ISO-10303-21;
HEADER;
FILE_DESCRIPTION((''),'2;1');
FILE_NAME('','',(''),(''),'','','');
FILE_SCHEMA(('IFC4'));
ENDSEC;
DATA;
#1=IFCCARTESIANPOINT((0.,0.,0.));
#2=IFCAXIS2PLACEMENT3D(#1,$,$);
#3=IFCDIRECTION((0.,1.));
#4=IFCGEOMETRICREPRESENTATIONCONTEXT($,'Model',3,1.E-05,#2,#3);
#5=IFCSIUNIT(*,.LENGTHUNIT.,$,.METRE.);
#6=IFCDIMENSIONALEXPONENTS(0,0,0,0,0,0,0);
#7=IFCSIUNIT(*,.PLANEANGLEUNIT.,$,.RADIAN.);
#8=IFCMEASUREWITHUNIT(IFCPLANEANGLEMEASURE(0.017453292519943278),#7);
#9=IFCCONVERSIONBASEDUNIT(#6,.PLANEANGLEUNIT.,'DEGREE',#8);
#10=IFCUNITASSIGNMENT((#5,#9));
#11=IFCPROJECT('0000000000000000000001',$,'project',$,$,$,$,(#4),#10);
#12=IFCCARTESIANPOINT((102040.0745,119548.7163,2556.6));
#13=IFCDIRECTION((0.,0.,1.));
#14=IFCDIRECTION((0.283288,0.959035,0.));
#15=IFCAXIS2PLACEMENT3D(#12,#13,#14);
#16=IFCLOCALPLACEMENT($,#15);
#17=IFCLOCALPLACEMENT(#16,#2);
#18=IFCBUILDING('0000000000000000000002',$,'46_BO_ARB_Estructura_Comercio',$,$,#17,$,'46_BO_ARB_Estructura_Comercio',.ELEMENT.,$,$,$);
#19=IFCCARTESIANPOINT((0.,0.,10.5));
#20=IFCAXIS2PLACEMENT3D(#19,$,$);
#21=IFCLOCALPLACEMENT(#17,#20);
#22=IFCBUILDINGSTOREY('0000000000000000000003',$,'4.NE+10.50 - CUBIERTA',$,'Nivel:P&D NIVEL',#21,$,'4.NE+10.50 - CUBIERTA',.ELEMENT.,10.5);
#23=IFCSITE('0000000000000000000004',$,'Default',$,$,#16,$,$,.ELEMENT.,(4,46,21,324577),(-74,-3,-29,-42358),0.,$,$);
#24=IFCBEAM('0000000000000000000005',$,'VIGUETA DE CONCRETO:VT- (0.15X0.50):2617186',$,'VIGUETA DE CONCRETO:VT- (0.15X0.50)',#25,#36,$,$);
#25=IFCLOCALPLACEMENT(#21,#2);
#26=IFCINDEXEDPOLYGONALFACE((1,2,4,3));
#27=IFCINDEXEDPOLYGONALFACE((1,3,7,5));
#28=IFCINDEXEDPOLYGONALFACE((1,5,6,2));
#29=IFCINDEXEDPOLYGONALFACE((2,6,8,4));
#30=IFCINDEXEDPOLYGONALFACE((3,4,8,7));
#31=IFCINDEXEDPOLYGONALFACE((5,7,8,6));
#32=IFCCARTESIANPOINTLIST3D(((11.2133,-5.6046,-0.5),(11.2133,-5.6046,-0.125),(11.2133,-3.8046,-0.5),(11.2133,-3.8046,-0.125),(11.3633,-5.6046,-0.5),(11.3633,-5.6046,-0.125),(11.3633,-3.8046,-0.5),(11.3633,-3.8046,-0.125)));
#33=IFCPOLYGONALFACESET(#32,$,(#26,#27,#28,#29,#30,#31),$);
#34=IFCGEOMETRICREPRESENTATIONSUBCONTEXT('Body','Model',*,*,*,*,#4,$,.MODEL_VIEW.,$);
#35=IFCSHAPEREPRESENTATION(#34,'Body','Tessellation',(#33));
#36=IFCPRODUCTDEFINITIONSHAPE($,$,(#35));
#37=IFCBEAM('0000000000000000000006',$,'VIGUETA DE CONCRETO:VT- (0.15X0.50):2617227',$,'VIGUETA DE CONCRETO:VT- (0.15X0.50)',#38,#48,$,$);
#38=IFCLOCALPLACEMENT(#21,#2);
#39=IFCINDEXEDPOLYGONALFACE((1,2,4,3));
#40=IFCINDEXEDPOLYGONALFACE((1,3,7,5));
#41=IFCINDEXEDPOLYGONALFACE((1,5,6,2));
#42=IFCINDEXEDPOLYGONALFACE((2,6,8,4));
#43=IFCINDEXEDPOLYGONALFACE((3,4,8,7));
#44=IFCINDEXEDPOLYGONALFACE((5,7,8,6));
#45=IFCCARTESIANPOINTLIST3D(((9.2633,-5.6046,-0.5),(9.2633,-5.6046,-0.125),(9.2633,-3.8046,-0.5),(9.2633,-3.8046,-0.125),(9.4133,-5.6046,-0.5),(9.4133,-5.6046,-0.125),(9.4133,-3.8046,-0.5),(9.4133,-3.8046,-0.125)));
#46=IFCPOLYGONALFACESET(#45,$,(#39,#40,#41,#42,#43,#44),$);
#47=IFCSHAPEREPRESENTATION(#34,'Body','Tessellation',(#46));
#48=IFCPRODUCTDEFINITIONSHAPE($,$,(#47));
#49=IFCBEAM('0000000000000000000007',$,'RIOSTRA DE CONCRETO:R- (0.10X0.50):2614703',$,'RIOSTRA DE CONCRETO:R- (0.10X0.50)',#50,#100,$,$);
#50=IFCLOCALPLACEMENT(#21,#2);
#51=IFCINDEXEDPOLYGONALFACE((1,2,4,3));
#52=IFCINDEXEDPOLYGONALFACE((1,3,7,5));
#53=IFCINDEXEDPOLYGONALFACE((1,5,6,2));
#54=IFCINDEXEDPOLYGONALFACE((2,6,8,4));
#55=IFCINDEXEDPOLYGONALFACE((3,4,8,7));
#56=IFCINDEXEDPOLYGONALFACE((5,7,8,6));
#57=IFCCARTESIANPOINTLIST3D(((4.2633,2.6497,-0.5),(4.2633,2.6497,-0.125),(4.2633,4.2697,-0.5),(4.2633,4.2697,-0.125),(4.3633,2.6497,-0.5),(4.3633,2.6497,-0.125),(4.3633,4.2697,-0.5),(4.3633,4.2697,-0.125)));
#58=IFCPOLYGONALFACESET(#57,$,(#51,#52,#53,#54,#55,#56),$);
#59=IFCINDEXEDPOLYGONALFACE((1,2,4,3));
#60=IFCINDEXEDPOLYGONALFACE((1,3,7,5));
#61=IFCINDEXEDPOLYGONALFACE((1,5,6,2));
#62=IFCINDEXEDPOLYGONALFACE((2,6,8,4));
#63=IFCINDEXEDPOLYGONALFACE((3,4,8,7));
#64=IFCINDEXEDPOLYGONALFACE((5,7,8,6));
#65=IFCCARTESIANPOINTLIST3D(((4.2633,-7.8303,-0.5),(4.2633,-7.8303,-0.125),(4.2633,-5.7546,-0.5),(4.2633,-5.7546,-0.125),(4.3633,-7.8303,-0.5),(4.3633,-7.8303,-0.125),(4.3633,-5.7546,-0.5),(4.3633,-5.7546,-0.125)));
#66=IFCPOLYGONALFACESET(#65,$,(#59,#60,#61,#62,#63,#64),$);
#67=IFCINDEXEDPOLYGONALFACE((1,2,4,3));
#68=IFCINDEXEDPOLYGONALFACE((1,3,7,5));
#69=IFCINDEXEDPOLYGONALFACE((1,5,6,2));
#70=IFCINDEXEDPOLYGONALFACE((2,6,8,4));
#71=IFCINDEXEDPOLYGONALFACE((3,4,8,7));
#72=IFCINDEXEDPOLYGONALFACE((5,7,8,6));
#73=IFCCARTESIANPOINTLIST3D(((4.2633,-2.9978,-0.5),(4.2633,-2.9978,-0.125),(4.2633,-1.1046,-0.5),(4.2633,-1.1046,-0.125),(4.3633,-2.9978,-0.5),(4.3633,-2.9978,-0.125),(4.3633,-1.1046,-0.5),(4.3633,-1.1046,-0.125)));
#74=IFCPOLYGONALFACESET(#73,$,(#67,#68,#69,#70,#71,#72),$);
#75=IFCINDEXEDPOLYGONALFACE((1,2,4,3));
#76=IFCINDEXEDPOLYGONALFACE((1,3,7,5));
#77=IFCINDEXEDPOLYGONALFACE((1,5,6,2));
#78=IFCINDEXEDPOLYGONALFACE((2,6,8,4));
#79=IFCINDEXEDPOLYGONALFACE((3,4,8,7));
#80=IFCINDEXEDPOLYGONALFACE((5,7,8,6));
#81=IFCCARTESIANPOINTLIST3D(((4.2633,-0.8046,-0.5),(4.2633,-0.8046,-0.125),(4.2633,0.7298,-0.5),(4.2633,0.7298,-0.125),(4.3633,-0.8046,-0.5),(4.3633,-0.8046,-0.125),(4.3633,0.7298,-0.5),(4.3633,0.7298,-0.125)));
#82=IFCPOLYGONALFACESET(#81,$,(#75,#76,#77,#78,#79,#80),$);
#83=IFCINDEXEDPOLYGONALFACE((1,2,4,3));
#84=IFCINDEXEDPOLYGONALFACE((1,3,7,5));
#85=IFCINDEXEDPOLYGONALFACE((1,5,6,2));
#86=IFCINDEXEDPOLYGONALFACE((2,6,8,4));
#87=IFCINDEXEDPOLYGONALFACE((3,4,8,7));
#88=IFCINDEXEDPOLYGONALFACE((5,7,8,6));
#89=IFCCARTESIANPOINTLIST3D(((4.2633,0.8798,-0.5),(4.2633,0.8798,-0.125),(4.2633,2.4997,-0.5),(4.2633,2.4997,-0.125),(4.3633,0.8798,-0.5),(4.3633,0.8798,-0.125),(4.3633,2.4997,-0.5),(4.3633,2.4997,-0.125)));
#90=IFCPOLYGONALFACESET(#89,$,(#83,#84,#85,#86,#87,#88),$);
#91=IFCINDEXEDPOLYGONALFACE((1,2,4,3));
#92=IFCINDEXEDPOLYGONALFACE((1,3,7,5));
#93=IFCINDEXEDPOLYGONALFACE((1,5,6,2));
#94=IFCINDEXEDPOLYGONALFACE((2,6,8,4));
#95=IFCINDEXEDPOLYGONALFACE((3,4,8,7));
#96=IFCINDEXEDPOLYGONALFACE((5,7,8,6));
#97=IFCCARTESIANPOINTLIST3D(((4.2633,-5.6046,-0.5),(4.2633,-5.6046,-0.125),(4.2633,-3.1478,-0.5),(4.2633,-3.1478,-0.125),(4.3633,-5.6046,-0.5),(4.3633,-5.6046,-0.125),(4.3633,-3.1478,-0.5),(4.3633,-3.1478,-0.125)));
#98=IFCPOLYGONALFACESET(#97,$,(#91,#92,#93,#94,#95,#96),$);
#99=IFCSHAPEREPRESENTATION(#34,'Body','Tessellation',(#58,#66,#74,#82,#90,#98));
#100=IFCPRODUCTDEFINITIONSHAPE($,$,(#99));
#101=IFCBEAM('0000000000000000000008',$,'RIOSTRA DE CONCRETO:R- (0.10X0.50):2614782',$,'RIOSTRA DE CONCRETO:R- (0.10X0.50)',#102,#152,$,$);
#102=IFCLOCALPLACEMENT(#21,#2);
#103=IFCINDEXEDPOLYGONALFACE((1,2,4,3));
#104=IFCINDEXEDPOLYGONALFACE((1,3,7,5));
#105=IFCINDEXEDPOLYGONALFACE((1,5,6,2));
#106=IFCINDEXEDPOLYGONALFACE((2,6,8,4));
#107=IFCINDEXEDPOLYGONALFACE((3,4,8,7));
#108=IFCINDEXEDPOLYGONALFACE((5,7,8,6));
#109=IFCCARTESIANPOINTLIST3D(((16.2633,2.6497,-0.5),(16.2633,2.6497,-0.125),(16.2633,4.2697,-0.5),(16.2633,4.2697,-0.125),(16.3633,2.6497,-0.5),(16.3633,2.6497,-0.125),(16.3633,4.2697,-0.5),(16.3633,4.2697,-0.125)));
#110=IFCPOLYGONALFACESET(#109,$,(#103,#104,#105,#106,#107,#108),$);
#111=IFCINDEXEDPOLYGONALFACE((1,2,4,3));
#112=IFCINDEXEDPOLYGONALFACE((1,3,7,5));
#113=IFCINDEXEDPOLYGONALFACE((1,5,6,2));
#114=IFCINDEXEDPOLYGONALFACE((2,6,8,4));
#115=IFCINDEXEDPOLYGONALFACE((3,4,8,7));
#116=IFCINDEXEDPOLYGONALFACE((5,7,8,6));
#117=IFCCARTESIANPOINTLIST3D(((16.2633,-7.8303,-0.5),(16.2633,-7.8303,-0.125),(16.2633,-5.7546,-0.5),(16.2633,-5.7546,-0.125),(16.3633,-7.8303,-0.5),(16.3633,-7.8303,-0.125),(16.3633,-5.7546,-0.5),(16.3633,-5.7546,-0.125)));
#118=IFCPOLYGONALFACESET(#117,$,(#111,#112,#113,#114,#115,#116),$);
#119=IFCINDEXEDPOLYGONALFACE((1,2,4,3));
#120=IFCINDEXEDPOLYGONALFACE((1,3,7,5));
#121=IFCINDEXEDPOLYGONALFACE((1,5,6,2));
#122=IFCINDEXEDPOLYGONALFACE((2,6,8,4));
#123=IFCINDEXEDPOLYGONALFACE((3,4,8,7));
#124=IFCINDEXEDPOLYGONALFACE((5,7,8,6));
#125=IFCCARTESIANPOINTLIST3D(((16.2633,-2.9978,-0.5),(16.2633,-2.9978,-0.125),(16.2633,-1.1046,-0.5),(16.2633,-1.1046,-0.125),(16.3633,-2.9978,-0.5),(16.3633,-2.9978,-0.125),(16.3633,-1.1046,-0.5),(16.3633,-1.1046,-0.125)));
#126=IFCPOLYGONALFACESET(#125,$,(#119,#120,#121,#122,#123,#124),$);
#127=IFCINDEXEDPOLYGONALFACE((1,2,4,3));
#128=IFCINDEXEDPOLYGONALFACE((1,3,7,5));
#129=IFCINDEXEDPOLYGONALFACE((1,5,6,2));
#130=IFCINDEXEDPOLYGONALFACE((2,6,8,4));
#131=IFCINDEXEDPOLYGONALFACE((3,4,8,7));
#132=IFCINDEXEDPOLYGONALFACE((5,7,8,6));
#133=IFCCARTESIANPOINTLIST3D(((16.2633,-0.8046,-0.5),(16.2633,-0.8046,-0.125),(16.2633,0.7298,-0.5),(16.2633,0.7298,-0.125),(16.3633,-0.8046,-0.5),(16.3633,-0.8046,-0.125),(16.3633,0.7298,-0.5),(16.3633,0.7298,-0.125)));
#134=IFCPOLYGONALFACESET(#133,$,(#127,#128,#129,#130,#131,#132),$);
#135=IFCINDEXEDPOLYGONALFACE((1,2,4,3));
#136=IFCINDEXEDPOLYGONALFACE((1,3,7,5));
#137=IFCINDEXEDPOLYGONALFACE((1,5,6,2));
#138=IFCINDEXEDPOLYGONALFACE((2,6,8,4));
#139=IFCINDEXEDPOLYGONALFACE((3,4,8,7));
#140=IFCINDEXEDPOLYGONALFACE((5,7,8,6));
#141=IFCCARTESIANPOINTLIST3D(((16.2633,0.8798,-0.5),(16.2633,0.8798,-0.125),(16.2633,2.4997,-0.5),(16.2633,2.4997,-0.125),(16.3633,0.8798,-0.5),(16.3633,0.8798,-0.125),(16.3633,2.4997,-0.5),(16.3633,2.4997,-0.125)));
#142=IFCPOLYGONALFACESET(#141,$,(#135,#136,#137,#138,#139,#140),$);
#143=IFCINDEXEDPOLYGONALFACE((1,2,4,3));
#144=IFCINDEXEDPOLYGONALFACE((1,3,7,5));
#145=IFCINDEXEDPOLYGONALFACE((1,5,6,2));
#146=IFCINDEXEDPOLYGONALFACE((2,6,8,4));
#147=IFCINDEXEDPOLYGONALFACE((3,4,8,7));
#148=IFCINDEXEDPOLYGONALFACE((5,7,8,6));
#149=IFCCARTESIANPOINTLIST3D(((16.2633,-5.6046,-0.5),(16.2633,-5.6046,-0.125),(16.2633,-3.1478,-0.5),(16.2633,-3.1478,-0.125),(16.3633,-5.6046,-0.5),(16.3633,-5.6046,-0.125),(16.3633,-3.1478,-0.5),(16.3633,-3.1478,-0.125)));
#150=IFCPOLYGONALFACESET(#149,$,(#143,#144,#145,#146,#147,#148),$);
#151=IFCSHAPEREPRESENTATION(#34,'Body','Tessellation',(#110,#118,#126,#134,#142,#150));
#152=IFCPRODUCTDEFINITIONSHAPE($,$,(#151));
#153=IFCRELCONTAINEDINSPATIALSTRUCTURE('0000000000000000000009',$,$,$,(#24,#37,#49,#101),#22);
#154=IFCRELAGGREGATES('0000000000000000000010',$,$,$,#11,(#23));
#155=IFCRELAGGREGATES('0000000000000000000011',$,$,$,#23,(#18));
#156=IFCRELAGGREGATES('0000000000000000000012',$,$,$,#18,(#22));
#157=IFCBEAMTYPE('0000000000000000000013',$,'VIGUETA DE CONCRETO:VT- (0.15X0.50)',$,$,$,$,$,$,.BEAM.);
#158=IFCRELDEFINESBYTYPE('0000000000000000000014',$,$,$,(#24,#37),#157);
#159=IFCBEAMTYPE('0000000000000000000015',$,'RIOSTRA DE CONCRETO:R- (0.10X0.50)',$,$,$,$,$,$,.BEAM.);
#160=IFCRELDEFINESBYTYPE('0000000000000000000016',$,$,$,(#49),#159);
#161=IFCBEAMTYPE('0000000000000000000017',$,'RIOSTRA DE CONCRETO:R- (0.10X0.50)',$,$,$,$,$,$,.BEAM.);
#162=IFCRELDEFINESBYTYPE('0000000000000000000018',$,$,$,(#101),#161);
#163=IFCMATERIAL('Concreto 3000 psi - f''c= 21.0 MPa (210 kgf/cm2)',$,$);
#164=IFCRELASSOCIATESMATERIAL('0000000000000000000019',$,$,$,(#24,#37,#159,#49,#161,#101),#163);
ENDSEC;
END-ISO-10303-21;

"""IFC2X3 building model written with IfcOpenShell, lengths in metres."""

from ifc_helpers import new_model, entity, si_unit, converted_unit, direction, frame, frame_2d, origin, place, context, subcontext, project, spatial, rectangle, extrude, source, transform, mapped, material, type_object, type_shapes, element, save


model = new_model("IFC2X3")

# Units and contexts
model_context = context("Model", 3, precision=1e-05, world=origin(), true_north=direction((0.0, 1.0)))
body_context = subcontext(model_context, "Body", "Model", "MODEL_VIEW")
ifc_project = project(units=[si_unit("LENGTHUNIT", "METRE"), converted_unit("PLANEANGLEUNIT", "DEGREE", entity("IfcPlaneAngleMeasure", 0.017453292519943278), si_unit("PLANEANGLEUNIT", "RADIAN"), dimensions=[0, 0, 0, 0, 0, 0, 0])], contexts=[model_context])

# Site, building, storey
site_placement = place(None, frame((102040.0745, 119548.7163, 2556.6), z_axis=(0.0, 0.0, 1.0), x_axis=(0.283288, 0.959035, 0.0)))
site = spatial("IfcSite", under=ifc_project, at=site_placement, Name="Default", CompositionType="ELEMENT", RefLatitude=(4, 46, 21, 324577), RefLongitude=(-74, -3, -29, -42358), RefElevation=0.0)
building_placement = place(site_placement, origin())
building = spatial("IfcBuilding", under=site, at=building_placement, Name="46_BO_ARB_Estructura_Comercio", LongName="46_BO_ARB_Estructura_Comercio", CompositionType="ELEMENT")
storey_placement = place(building_placement, frame((0.0, 0.0, 10.5)))
storey = spatial("IfcBuildingStorey", under=building, at=storey_placement, Name="4.NE+10.50 - CUBIERTA", ObjectType="Nivel:P&D NIVEL", LongName="4.NE+10.50 - CUBIERTA", CompositionType="ELEMENT", Elevation=10.5)

# Beams
ifc_material = material(Name="Concreto 3000 psi - f'c= 21.0 MPa (210 kgf/cm2)")
beam_type_1 = type_object("IfcBeamType", Name="VIGUETA DE CONCRETO:VT- (0.15X0.50)", PredefinedType="BEAM")
beam_1_placement = place(storey_placement, frame((11.2883, -3.7296, 0.0), z_axis=(0.0, 0.0, 1.0), x_axis=(0.0, -1.0, 0.0)))
element("IfcBeam", 1, at=beam_1_placement, inside=storey, type_object=beam_type_1, material=ifc_material, Name="VIGUETA DE CONCRETO:VT- (0.15X0.50):2617186", ObjectType="VIGUETA DE CONCRETO:VT- (0.15X0.50)", context=body_context, shape_type="SweptSolid", body=[
    extrude(rectangle(XDim=0.375, YDim=0.15, at=frame_2d((0.0, 0.0), x_axis=(1.0, 0.0))), frame((0.075, 0.0, -0.3125), z_axis=(1.0, 0.0, 0.0), x_axis=(0.0, 0.0, -1.0)), (0.0, 0.0, 1.0), 1.8),
])
beam_2_placement = place(storey_placement, frame((9.3383, -3.7296, 0.0), z_axis=(0.0, 0.0, 1.0), x_axis=(0.0, -1.0, 0.0)))
element("IfcBeam", 2, at=beam_2_placement, inside=storey, type_object=beam_type_1, material=ifc_material, Name="VIGUETA DE CONCRETO:VT- (0.15X0.50):2617227", ObjectType="VIGUETA DE CONCRETO:VT- (0.15X0.50)", context=body_context, shape_type="SweptSolid", body=[
    extrude(rectangle(XDim=0.375, YDim=0.15, at=frame_2d((0.0, 0.0), x_axis=(1.0, 0.0))), frame((0.075, 0.0, -0.3125), z_axis=(1.0, 0.0, 0.0), x_axis=(0.0, 0.0, -1.0)), (0.0, 0.0, 1.0), 1.8),
])
beam_type_2 = type_object("IfcBeamType", Name="RIOSTRA DE CONCRETO:R- (0.10X0.50)", PredefinedType="BEAM", material=ifc_material)
shared_shape_1 = source(origin(), body_context, "Body", "SweptSolid", [
    extrude(rectangle(XDim=0.375, YDim=0.1, at=frame_2d((0.0, 0.0), x_axis=(0.0, 1.0))), frame((4.3133, 2.6497, 10.1875), z_axis=(0.0, 1.0, 0.0), x_axis=(-1.0, 0.0, 0.0)), (0.0, 0.0, 1.0), 1.62),
    extrude(rectangle(XDim=0.375, YDim=0.1, at=frame_2d((0.0, 0.0), x_axis=(0.0, 1.0))), frame((4.3133, -7.8303, 10.1875), z_axis=(0.0, 1.0, 0.0), x_axis=(-1.0, 0.0, 0.0)), (0.0, 0.0, 1.0), 2.0757),
    extrude(rectangle(XDim=0.375, YDim=0.1, at=frame_2d((0.0, 0.0), x_axis=(0.0, 1.0))), frame((4.3133, -2.9978, 10.1875), z_axis=(0.0, 1.0, 0.0), x_axis=(-1.0, 0.0, 0.0)), (0.0, 0.0, 1.0), 1.8932),
    extrude(rectangle(XDim=0.375, YDim=0.1, at=frame_2d((0.0, 0.0), x_axis=(0.0, 1.0))), frame((4.3133, -0.8046, 10.1875), z_axis=(0.0, 1.0, 0.0), x_axis=(-1.0, 0.0, 0.0)), (0.0, 0.0, 1.0), 1.5344),
    extrude(rectangle(XDim=0.375, YDim=0.1, at=frame_2d((0.0, 0.0), x_axis=(0.0, 1.0))), frame((4.3133, 0.8798, 10.1875), z_axis=(0.0, 1.0, 0.0), x_axis=(-1.0, 0.0, 0.0)), (0.0, 0.0, 1.0), 1.62),
    extrude(rectangle(XDim=0.375, YDim=0.1, at=frame_2d((0.0, 0.0), x_axis=(0.0, 1.0))), frame((4.3133, -5.6046, 10.1875), z_axis=(0.0, 1.0, 0.0), x_axis=(-1.0, 0.0, 0.0)), (0.0, 0.0, 1.0), 2.4568),
])
type_shapes(beam_type_2, [shared_shape_1])
beam_3_placement = place(storey_placement, frame((0.0, 0.0, -10.5)))
element("IfcBeam", 3, at=beam_3_placement, inside=storey, type_object=beam_type_2, material=ifc_material, Name="RIOSTRA DE CONCRETO:R- (0.10X0.50):2614703", ObjectType="RIOSTRA DE CONCRETO:R- (0.10X0.50)", context=body_context, shape_type="MappedRepresentation", body=[
    mapped(shared_shape_1, transform((0.0, 0.0, 0.0), scale=1.0)),
])
beam_type_3 = type_object("IfcBeamType", Name="RIOSTRA DE CONCRETO:R- (0.10X0.50)", PredefinedType="BEAM", material=ifc_material)
shared_shape_2 = source(origin(), body_context, "Body", "SweptSolid", [
    extrude(rectangle(XDim=0.375, YDim=0.1, at=frame_2d((0.0, 0.0), x_axis=(0.0, 1.0))), frame((16.3133, 2.6497, 10.1875), z_axis=(0.0, 1.0, 0.0), x_axis=(-1.0, 0.0, 0.0)), (0.0, 0.0, 1.0), 1.62),
    extrude(rectangle(XDim=0.375, YDim=0.1, at=frame_2d((0.0, 0.0), x_axis=(0.0, 1.0))), frame((16.3133, -7.8303, 10.1875), z_axis=(0.0, 1.0, 0.0), x_axis=(-1.0, 0.0, 0.0)), (0.0, 0.0, 1.0), 2.0757),
    extrude(rectangle(XDim=0.375, YDim=0.1, at=frame_2d((0.0, 0.0), x_axis=(0.0, 1.0))), frame((16.3133, -2.9978, 10.1875), z_axis=(0.0, 1.0, 0.0), x_axis=(-1.0, 0.0, 0.0)), (0.0, 0.0, 1.0), 1.8932),
    extrude(rectangle(XDim=0.375, YDim=0.1, at=frame_2d((0.0, 0.0), x_axis=(0.0, 1.0))), frame((16.3133, -0.8046, 10.1875), z_axis=(0.0, 1.0, 0.0), x_axis=(-1.0, 0.0, 0.0)), (0.0, 0.0, 1.0), 1.5344),
    extrude(rectangle(XDim=0.375, YDim=0.1, at=frame_2d((0.0, 0.0), x_axis=(0.0, 1.0))), frame((16.3133, 0.8798, 10.1875), z_axis=(0.0, 1.0, 0.0), x_axis=(-1.0, 0.0, 0.0)), (0.0, 0.0, 1.0), 1.62),
    extrude(rectangle(XDim=0.375, YDim=0.1, at=frame_2d((0.0, 0.0), x_axis=(0.0, 1.0))), frame((16.3133, -5.6046, 10.1875), z_axis=(0.0, 1.0, 0.0), x_axis=(-1.0, 0.0, 0.0)), (0.0, 0.0, 1.0), 2.4568),
])
type_shapes(beam_type_3, [shared_shape_2])
beam_4_placement = place(storey_placement, frame((0.0, 0.0, -10.5)))
element("IfcBeam", 4, at=beam_4_placement, inside=storey, type_object=beam_type_3, material=ifc_material, Name="RIOSTRA DE CONCRETO:R- (0.10X0.50):2614782", ObjectType="RIOSTRA DE CONCRETO:R- (0.10X0.50)", context=body_context, shape_type="MappedRepresentation", body=[
    mapped(shared_shape_2, transform((0.0, 0.0, 0.0), scale=1.0)),
])

save(model, "model.ifc")
